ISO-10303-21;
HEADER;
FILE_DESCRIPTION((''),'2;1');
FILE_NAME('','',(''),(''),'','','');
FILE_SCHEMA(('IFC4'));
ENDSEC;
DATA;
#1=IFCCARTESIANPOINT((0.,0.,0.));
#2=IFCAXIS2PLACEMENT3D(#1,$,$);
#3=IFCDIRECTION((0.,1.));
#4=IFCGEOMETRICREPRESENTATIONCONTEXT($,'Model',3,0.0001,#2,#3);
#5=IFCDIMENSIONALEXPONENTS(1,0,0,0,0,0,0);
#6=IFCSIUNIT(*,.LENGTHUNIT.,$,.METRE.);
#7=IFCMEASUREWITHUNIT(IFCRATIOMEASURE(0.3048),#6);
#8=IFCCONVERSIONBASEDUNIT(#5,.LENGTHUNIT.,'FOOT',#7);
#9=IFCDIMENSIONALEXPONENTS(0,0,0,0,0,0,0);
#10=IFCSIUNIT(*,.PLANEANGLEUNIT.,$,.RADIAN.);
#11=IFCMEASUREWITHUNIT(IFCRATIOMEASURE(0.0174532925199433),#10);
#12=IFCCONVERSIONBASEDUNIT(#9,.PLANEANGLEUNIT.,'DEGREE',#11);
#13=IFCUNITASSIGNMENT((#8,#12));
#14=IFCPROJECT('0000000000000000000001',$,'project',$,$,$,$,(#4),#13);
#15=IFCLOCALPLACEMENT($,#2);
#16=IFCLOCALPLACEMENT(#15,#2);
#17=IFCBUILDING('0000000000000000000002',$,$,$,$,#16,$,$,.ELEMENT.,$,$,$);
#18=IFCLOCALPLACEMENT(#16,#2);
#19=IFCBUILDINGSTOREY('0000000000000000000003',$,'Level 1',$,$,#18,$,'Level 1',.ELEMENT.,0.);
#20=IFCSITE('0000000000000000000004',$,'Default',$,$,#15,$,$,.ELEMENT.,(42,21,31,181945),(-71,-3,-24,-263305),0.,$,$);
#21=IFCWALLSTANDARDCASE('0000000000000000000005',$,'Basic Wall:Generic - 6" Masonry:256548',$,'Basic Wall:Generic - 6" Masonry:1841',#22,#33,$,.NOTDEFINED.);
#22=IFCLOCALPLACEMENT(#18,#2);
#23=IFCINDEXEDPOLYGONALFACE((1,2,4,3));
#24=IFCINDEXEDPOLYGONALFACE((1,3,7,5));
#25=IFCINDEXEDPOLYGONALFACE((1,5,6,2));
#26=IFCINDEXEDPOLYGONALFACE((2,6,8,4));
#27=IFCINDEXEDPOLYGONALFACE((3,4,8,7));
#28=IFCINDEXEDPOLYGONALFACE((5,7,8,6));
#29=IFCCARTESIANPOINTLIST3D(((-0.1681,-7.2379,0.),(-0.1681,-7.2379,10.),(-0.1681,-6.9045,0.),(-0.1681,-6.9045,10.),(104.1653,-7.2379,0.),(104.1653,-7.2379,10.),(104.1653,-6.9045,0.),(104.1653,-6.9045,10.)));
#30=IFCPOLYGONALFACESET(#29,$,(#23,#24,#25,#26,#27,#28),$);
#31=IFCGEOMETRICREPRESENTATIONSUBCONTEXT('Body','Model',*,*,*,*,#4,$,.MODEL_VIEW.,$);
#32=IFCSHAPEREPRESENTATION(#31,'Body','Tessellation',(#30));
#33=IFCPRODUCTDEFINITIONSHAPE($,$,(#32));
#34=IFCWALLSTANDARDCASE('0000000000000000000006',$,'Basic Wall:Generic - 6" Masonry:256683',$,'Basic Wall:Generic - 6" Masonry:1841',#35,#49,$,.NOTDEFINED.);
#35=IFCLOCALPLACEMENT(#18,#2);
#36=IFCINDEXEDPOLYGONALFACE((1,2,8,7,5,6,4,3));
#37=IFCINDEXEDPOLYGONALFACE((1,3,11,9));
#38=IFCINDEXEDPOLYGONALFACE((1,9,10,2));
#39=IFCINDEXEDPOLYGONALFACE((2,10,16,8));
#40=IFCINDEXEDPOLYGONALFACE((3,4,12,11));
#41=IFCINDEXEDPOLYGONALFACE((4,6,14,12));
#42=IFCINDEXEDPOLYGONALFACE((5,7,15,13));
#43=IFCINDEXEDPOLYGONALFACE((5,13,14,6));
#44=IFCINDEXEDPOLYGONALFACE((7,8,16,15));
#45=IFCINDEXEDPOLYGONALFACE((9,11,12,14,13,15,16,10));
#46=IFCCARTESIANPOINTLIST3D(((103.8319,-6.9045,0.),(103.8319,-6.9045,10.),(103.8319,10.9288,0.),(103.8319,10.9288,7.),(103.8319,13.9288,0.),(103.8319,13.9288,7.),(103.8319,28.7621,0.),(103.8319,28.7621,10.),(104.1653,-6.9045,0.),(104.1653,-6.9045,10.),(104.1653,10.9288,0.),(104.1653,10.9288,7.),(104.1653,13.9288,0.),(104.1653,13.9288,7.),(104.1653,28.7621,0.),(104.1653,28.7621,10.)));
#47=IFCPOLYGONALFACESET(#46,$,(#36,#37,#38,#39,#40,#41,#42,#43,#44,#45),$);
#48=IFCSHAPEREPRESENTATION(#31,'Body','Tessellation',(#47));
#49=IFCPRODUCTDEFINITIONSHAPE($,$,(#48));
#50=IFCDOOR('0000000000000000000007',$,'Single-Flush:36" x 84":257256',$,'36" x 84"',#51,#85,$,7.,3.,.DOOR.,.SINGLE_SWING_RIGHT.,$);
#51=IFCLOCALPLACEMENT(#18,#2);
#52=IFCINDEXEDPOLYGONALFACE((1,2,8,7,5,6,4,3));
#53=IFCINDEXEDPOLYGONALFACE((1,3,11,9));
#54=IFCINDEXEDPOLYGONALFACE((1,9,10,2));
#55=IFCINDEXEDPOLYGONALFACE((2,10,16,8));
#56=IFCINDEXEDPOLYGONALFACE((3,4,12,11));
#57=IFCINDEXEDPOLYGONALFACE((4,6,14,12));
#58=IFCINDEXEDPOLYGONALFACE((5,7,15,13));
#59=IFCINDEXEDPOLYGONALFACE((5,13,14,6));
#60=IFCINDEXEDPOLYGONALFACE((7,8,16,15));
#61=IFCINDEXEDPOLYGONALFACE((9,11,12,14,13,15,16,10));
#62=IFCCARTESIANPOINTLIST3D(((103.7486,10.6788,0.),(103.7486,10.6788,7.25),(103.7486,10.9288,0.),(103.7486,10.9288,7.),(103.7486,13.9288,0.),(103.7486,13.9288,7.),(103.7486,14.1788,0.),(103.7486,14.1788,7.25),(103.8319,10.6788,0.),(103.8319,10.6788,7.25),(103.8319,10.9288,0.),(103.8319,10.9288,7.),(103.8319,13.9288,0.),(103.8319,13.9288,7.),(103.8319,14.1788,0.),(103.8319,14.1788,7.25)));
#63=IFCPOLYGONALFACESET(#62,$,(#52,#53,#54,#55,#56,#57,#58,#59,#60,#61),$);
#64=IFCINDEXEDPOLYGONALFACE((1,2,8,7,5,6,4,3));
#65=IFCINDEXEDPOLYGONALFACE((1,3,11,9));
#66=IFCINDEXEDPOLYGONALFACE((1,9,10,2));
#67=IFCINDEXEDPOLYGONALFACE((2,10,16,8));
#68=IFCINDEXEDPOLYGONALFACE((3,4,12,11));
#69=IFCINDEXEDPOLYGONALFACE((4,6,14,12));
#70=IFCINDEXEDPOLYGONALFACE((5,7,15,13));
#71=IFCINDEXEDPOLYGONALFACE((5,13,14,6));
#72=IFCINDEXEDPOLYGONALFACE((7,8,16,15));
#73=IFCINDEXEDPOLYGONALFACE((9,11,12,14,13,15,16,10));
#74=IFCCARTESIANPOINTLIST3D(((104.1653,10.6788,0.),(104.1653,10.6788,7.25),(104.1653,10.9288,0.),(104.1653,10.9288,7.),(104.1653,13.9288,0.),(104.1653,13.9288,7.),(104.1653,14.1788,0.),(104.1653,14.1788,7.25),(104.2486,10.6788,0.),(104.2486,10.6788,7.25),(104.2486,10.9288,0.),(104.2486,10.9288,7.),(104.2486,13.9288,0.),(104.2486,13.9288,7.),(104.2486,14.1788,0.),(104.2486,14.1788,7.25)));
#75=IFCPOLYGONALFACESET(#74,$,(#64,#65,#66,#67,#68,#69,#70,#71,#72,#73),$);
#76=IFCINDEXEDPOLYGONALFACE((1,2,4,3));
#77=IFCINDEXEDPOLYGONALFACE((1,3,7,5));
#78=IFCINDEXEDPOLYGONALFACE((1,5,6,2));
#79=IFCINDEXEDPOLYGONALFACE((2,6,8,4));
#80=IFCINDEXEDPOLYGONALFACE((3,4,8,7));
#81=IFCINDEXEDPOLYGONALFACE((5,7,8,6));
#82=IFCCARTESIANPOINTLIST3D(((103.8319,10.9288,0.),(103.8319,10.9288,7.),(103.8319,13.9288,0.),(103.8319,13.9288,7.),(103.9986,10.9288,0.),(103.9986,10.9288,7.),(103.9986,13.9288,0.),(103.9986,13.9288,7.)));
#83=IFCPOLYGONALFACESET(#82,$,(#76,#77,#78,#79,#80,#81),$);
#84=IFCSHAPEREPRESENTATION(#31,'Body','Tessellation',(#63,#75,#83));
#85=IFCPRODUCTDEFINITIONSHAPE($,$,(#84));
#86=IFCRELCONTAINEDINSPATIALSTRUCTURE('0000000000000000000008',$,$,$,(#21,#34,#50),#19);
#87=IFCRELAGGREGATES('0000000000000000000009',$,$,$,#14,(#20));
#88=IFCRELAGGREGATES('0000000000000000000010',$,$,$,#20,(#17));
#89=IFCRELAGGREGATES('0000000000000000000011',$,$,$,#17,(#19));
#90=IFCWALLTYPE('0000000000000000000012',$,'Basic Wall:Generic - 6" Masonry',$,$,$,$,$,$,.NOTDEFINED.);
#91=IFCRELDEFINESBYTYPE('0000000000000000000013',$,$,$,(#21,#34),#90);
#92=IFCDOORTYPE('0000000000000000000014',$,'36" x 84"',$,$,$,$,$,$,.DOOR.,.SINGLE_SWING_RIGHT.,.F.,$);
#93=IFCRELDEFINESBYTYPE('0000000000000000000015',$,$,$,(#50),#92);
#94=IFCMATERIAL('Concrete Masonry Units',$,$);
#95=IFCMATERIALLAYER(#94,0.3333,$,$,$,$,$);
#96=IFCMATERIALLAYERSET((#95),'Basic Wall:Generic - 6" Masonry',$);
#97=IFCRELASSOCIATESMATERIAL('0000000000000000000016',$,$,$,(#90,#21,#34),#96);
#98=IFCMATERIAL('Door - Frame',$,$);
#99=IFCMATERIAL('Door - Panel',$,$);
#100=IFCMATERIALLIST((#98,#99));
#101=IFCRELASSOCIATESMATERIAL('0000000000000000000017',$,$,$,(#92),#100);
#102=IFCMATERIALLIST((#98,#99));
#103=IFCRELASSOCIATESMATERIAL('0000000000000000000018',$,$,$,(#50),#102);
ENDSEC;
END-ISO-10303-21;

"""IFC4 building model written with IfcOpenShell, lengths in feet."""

from ifc_helpers import new_model, entity, si_unit, converted_unit, direction, frame, frame_2d, origin, place, context, subcontext, project, spatial, polyline, rectangle, outline, extrude, source, transform, mapped, material, material_list, layer, layer_set, layer_usage, type_object, type_shapes, element, fill, save


model = new_model("IFC4")

# Units and contexts
model_context = context("Model", 3, precision=0.0001, world=origin(), true_north=direction((0.0, 1.0)))
body_context = subcontext(model_context, "Body", "Model", "MODEL_VIEW")
ifc_project = project(units=[converted_unit("LENGTHUNIT", "FOOT", entity("IfcRatioMeasure", 0.3048), si_unit("LENGTHUNIT", "METRE"), dimensions=[1, 0, 0, 0, 0, 0, 0]), converted_unit("PLANEANGLEUNIT", "DEGREE", entity("IfcRatioMeasure", 0.0174532925199433), si_unit("PLANEANGLEUNIT", "RADIAN"), dimensions=[0, 0, 0, 0, 0, 0, 0])], contexts=[model_context])

# Site, building, storey
site_placement = place(None, origin())
site = spatial("IfcSite", under=ifc_project, at=site_placement, Name="Default", CompositionType="ELEMENT", RefLatitude=(42, 21, 31, 181945), RefLongitude=(-71, -3, -24, -263305), RefElevation=0.0)
building_placement = place(site_placement, origin())
building = spatial("IfcBuilding", under=site, at=building_placement, CompositionType="ELEMENT")
storey_placement = place(building_placement, origin())
storey = spatial("IfcBuildingStorey", under=building, at=storey_placement, Name="Level 1", LongName="Level 1", CompositionType="ELEMENT", Elevation=0.0)

# Shared definitions
wall_1_placement = place(storey_placement, frame((104.1653, -7.0712, 0.0), z_axis=(0.0, 0.0, 1.0), x_axis=(-1.0, 0.0, 0.0)))
wall_2_placement = place(storey_placement, frame((103.9986, -6.9045, 0.0), z_axis=(0.0, 0.0, 1.0), x_axis=(0.0, 1.0, 0.0)))

# Wall
ifc_material_1 = material(Name="Concrete Masonry Units")
ifc_layer = layer(ifc_material_1, 0.3333)
ifc_layer_set = layer_set([ifc_layer], Name="Basic Wall:Generic - 6\" Masonry")
ifc_layer_usage_1 = layer_usage(ifc_layer_set, "AXIS2", "NEGATIVE", 0.1667)
wall_type = type_object("IfcWallType", Name="Basic Wall:Generic - 6\" Masonry", PredefinedType="NOTDEFINED", material=ifc_layer_set)
element("IfcWallStandardCase", 1, at=wall_1_placement, inside=storey, type_object=wall_type, material=ifc_layer_usage_1, Name="Basic Wall:Generic - 6\" Masonry:256548", ObjectType="Basic Wall:Generic - 6\" Masonry:1841", PredefinedType="NOTDEFINED", context=body_context, shape_type="SweptSolid", body=[
    extrude(rectangle(XDim=104.3333, YDim=0.3333, at=frame_2d((52.1667, 0.0), x_axis=(-1.0, 0.0))), origin(), (0.0, 0.0, 1.0), 10.0),
])

# Wall, opening, door
ifc_layer_usage_2 = layer_usage(ifc_layer_set, "AXIS2", "NEGATIVE", 0.1667)
wall_2 = element("IfcWallStandardCase", 2, at=wall_2_placement, inside=storey, type_object=wall_type, material=ifc_layer_usage_2, Name="Basic Wall:Generic - 6\" Masonry:256683", ObjectType="Basic Wall:Generic - 6\" Masonry:1841", PredefinedType="NOTDEFINED", context=body_context, shape_type="SweptSolid", body=[
    extrude(rectangle(XDim=35.6667, YDim=0.3333, at=frame_2d((17.8333, 0.0), x_axis=(-1.0, 0.0))), origin(), (0.0, 0.0, 1.0), 10.0),
])
opening_1_placement = place(wall_2_placement, frame((17.8333, -0.1667, 0.0)))
opening_1 = element("IfcOpeningElement", 3, at=opening_1_placement, cuts=wall_2, ObjectType="Opening", PredefinedType="OPENING", context=body_context, shape_type="SweptSolid", body=[
    extrude(rectangle(XDim=3.0, YDim=7.0, at=frame_2d((3.5, 1.5), x_axis=(0.0, 1.0))), frame((0.0, 0.0, 0.0), z_axis=(0.0, 1.0, 0.0), x_axis=(0.0, 0.0, 1.0)), (0.0, 0.0, 1.0), 0.3333),
])
ifc_material_2 = material(Name="Door - Frame")
ifc_material_3 = material(Name="Door - Panel")
ifc_material_list_1 = material_list([ifc_material_2, ifc_material_3])
ifc_material_list_2 = material_list([ifc_material_2, ifc_material_3])
door_type = type_object("IfcDoorType", Name="36\" x 84\"", OperationType="SINGLE_SWING_RIGHT", ParameterTakesPrecedence=False, PredefinedType="DOOR", material=ifc_material_list_2)
shared_shape_1 = source(origin(), body_context, "Body", "SweptSolid", [
    extrude(outline(polyline([(-1.75, -3.6875), (1.75, -3.6875), (1.75, 3.5625), (1.5, 3.5625), (1.5, -3.4375), (-1.5, -3.4375), (-1.5, 3.5625), (-1.75, 3.5625), (-1.75, -3.6875)])), frame((1.5, 0.3333, 3.5625), z_axis=(0.0, 1.0, 0.0), x_axis=(1.0, 0.0, 0.0)), (0.0, 0.0, 1.0), 0.0833),
    extrude(outline(polyline([(-3.6875, -1.75), (3.5625, -1.75), (3.5625, -1.5), (-3.4375, -1.5), (-3.4375, 1.5), (3.5625, 1.5), (3.5625, 1.75), (-3.6875, 1.75), (-3.6875, -1.75)])), frame((1.5, -0.0833, 3.5625), z_axis=(0.0, 1.0, 0.0), x_axis=(0.0, 0.0, -1.0)), (0.0, 0.0, 1.0), 0.0833),
    extrude(rectangle(XDim=0.1667, YDim=3.0, at=frame_2d((0.0, 0.0), x_axis=(1.0, 0.0))), frame((1.5, 0.25, 0.0), z_axis=(0.0, 0.0, 1.0), x_axis=(0.0, 1.0, 0.0)), (0.0, 0.0, 1.0), 7.0),
])
type_shapes(door_type, [shared_shape_1])
door_1_placement = place(opening_1_placement, origin())
door_1 = element("IfcDoor", 4, at=door_1_placement, inside=storey, type_object=door_type, material=ifc_material_list_1, Name="Single-Flush:36\" x 84\":257256", ObjectType="36\" x 84\"", OperationType="SINGLE_SWING_RIGHT", OverallHeight=7.0, OverallWidth=3.0, PredefinedType="DOOR", context=body_context, shape_type="MappedRepresentation", body=[
    mapped(shared_shape_1, transform((0.0, 0.0, 0.0), scale=1.0)),
])
fill(opening_1, door_1)

save(model, "model.ifc")
